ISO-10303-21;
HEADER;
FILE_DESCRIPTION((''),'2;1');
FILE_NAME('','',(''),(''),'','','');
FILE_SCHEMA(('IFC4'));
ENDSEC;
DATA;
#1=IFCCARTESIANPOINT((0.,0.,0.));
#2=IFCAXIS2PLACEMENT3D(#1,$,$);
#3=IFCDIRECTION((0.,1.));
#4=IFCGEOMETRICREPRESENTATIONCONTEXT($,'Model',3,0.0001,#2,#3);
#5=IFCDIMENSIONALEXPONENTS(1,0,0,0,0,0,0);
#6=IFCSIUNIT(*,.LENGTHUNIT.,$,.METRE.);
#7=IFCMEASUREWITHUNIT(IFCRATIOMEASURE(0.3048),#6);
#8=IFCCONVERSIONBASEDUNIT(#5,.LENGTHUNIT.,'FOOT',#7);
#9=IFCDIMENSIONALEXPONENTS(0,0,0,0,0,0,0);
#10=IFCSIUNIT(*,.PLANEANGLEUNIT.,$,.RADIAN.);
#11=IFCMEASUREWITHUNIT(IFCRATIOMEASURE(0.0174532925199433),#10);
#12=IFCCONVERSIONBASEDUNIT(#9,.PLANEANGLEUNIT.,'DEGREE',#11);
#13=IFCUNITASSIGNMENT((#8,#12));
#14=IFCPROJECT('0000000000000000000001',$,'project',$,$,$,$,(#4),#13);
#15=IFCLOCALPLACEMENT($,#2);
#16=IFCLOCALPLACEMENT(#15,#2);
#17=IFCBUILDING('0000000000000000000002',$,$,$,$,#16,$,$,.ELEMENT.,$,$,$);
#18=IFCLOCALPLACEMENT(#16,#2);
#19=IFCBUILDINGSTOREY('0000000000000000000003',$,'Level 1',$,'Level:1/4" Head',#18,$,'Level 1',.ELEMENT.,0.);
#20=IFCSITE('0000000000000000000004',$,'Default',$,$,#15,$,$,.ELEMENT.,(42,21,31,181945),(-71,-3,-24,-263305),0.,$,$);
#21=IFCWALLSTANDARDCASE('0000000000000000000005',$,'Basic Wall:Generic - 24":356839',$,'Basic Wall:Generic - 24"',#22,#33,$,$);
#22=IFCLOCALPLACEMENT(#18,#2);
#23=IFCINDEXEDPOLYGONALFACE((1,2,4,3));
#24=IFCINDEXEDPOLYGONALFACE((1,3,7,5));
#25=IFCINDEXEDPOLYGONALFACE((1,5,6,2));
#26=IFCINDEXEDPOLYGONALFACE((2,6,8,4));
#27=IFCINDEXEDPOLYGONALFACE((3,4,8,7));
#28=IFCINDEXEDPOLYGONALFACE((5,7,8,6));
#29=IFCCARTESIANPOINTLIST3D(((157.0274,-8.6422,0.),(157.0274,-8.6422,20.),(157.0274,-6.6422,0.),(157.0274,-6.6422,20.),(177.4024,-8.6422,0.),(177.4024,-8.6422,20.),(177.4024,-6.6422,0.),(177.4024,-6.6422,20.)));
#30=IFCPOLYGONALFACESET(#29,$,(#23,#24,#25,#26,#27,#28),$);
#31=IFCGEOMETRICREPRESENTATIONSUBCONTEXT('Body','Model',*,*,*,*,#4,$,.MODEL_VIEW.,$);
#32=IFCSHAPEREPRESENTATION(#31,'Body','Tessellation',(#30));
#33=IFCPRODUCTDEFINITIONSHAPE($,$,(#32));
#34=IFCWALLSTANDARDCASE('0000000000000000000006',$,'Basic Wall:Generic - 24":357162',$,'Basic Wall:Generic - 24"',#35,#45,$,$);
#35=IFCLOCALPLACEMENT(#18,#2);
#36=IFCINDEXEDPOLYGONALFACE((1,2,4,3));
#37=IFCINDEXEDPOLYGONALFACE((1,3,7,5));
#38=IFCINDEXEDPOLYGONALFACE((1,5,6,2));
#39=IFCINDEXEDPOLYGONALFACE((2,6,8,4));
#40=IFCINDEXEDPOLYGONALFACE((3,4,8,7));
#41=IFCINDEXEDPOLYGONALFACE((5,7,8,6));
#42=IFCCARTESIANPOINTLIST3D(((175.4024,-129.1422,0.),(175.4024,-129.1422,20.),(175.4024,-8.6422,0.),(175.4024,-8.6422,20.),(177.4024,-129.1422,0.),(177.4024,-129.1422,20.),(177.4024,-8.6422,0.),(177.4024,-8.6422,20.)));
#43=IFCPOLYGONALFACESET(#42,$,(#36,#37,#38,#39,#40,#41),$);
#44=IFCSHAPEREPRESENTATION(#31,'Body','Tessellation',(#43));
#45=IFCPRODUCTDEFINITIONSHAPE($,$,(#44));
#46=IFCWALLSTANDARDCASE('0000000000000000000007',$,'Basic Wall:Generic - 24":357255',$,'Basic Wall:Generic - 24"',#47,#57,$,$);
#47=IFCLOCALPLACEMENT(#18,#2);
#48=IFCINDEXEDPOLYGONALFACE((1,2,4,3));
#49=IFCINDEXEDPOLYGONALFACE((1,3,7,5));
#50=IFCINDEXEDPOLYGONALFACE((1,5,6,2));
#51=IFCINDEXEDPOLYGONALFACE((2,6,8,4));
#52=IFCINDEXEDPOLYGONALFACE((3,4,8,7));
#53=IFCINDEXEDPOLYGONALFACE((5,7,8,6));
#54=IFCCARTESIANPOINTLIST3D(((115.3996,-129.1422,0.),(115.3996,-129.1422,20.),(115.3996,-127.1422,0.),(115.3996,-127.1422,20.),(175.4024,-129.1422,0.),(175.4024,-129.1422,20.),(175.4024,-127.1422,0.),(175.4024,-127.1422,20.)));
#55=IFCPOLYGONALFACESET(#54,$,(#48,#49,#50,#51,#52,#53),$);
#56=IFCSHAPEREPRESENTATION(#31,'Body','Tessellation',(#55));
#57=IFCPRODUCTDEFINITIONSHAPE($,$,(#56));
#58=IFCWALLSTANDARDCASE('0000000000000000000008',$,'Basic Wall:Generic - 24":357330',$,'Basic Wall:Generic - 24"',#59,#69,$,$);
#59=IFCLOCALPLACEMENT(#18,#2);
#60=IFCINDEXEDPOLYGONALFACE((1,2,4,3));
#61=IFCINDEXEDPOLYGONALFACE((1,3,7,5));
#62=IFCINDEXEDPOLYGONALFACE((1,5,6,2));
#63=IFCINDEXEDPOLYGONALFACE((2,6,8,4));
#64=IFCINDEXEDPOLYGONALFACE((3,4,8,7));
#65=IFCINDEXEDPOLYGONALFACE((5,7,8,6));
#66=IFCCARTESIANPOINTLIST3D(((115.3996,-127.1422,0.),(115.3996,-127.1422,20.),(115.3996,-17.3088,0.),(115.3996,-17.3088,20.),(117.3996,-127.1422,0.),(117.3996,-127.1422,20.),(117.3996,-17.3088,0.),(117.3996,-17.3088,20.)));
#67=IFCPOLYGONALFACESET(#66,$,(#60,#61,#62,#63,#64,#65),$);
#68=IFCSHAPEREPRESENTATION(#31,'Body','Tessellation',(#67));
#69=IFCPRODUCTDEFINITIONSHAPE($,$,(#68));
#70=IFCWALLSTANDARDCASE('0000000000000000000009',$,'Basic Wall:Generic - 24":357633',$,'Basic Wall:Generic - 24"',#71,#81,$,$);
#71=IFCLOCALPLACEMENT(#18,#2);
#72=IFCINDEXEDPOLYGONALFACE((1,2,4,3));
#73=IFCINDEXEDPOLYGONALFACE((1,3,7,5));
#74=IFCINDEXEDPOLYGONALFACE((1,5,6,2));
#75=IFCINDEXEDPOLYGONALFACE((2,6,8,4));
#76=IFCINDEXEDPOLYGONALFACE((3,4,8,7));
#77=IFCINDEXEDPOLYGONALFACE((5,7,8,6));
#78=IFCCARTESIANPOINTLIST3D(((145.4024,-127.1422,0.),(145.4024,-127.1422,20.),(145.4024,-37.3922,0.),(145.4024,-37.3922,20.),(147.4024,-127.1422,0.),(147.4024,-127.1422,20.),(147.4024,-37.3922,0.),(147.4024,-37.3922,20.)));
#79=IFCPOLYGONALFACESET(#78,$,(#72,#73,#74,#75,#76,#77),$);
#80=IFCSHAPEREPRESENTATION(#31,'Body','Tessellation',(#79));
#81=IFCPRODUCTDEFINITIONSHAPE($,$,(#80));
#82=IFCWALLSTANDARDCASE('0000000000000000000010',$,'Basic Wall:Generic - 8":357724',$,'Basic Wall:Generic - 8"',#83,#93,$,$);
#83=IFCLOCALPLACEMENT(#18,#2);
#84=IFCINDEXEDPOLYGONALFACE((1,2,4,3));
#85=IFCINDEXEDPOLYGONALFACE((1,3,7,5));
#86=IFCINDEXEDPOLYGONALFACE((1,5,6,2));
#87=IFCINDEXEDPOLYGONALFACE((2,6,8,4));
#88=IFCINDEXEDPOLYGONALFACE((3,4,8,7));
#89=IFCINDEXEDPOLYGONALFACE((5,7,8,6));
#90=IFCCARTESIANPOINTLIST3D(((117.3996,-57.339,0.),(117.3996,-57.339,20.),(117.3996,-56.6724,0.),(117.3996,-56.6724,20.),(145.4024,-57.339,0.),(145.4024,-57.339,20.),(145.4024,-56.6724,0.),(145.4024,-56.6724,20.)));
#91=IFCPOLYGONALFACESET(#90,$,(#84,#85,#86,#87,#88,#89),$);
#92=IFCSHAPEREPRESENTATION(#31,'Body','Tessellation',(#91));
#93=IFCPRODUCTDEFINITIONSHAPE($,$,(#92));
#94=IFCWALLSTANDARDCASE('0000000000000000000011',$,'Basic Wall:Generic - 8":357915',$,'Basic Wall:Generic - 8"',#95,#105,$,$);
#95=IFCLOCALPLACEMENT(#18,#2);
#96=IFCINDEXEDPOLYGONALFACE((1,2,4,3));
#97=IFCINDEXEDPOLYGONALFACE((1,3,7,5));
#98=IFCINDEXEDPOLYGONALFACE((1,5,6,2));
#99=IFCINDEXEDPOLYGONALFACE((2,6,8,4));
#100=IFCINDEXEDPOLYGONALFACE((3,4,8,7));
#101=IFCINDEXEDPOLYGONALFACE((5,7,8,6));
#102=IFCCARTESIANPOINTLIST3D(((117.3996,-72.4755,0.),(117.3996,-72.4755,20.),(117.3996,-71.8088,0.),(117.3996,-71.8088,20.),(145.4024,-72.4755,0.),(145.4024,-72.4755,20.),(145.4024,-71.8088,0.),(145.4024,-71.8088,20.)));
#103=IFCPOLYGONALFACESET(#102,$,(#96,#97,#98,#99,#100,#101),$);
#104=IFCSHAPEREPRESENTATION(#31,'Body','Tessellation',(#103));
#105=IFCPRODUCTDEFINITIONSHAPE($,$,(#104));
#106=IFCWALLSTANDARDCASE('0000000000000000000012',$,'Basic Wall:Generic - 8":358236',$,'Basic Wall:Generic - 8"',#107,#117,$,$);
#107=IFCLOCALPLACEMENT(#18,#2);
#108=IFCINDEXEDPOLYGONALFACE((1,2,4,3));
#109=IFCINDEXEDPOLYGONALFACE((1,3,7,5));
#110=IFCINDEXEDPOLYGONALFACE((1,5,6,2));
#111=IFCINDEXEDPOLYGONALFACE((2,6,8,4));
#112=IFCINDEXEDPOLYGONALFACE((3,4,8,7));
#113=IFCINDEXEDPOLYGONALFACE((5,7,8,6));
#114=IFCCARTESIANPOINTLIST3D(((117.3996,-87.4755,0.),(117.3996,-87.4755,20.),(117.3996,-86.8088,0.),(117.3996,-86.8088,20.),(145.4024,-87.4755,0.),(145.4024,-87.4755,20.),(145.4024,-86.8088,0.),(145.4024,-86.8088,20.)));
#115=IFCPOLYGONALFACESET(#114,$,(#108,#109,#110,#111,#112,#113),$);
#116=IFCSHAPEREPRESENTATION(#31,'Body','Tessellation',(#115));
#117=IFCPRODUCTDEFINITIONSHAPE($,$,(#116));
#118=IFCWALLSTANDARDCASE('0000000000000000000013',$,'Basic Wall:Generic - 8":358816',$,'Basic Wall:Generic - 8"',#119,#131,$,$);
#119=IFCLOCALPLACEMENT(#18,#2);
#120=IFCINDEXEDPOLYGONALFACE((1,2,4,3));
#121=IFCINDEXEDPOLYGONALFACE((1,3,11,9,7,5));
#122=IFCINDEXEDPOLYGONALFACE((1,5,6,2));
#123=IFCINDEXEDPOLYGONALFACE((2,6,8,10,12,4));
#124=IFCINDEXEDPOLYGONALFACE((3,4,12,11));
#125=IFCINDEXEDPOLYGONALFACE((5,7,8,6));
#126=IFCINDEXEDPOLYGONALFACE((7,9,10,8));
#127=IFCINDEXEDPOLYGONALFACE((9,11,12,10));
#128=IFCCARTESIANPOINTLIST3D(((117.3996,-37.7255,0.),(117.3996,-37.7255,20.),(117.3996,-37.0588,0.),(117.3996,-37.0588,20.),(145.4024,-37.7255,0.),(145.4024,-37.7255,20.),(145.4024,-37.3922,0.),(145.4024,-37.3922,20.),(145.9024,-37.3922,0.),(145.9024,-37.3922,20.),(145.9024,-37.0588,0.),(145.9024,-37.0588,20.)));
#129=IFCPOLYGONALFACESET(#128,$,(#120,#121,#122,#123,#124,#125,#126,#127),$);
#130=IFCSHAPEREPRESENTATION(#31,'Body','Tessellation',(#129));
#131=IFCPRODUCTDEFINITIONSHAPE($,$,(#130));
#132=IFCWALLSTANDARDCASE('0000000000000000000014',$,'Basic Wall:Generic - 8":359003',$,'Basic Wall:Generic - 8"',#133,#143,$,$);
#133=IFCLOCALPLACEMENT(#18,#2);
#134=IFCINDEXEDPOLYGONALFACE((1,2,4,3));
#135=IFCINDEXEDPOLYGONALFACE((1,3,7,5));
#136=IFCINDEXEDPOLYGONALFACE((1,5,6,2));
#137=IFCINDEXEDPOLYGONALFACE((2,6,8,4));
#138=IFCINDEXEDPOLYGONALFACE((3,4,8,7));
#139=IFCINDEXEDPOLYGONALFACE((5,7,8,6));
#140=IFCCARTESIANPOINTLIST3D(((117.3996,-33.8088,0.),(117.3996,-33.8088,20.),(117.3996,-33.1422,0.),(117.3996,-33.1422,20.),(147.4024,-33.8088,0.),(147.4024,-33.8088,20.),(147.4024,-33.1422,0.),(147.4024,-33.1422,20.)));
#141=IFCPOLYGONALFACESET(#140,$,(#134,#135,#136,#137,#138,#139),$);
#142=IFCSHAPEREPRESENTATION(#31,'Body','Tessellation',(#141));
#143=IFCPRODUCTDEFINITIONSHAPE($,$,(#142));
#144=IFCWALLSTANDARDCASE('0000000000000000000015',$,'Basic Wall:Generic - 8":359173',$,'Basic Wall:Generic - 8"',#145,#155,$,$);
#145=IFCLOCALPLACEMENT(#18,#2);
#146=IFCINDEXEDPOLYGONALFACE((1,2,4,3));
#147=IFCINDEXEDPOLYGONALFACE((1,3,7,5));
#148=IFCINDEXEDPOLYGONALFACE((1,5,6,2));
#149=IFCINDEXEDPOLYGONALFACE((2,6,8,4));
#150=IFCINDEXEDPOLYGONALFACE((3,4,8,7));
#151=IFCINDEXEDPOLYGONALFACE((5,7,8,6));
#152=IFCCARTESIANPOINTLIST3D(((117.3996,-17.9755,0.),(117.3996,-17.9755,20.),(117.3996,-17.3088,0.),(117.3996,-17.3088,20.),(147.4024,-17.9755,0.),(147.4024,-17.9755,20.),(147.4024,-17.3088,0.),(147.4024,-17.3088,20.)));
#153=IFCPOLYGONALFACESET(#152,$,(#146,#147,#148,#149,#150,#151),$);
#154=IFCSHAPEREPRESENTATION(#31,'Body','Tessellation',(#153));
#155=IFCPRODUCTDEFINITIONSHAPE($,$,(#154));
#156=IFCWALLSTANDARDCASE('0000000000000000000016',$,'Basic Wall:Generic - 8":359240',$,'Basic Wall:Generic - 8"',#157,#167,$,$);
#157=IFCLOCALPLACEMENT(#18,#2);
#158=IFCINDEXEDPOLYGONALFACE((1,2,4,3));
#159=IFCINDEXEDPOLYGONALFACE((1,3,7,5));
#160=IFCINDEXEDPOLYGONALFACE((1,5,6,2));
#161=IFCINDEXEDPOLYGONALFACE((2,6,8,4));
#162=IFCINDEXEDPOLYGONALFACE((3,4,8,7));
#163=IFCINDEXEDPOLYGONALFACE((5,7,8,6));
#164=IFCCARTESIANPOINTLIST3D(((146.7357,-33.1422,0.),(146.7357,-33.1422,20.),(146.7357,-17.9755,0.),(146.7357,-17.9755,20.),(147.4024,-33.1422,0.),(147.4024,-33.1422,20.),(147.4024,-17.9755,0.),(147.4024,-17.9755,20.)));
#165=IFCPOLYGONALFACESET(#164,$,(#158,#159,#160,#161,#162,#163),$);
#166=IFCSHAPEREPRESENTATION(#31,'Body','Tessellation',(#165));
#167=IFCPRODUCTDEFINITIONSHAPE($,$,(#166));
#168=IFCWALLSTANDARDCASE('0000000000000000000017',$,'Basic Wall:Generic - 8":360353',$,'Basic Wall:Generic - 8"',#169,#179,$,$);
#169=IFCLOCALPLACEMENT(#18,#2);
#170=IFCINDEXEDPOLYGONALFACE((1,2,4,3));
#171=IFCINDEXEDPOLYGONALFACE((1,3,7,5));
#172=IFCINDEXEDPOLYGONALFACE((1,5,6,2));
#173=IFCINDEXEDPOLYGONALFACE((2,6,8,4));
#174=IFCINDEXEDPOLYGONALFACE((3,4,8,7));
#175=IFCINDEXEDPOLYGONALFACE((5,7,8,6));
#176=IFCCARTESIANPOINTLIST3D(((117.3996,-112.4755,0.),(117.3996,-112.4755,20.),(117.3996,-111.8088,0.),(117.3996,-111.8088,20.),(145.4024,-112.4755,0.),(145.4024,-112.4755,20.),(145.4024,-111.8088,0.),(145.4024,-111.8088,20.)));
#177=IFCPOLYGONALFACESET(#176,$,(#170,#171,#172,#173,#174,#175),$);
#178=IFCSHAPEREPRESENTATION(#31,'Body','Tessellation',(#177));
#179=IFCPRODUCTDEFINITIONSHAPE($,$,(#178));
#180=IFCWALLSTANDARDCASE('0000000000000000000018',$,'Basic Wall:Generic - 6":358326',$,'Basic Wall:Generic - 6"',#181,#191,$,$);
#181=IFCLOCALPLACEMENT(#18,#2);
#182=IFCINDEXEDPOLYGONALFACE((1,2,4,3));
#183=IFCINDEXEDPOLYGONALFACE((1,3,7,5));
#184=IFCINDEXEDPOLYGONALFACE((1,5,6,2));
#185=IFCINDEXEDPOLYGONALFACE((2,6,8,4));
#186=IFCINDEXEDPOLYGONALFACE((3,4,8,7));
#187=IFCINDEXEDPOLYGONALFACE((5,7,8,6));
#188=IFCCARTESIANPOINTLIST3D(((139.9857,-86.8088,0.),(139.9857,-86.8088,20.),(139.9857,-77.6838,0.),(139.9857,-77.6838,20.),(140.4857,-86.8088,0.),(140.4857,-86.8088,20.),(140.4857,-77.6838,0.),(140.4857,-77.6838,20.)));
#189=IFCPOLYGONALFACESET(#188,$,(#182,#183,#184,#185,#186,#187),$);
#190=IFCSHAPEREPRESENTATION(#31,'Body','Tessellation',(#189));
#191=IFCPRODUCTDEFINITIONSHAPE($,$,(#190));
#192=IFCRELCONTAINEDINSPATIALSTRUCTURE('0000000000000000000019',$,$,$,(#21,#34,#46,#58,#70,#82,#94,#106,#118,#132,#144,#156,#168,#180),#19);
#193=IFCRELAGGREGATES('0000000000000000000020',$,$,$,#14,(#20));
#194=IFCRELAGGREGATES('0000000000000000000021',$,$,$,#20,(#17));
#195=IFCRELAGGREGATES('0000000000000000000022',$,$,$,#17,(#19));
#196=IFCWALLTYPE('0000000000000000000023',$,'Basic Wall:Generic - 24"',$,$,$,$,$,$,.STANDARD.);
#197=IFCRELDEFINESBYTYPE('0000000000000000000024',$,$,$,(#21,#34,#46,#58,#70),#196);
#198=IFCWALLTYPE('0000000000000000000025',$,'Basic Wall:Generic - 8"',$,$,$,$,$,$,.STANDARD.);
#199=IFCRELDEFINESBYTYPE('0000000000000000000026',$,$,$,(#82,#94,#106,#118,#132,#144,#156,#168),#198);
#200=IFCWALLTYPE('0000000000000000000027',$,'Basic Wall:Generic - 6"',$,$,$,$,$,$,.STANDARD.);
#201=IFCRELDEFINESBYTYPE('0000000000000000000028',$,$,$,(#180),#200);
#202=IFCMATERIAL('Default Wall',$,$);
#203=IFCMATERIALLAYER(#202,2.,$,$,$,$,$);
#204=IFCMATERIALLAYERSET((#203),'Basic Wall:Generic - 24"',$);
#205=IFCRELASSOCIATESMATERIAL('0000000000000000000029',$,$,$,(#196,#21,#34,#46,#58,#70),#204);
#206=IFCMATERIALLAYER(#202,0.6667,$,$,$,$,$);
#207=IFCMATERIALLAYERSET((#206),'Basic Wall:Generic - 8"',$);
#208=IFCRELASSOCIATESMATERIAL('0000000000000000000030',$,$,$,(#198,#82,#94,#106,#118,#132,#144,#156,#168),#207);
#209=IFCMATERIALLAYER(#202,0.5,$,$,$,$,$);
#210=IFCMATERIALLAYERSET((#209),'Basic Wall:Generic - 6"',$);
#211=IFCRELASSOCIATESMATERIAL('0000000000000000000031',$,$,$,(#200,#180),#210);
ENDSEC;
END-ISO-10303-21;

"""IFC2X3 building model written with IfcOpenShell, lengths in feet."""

from ifc_helpers import new_model, entity, si_unit, converted_unit, direction, frame, frame_2d, origin, place, context, subcontext, project, spatial, polyline, rectangle, outline, extrude, material, layer, layer_set, layer_usage, type_object, element, save


model = new_model("IFC2X3")

# Units and contexts
model_context = context("Model", 3, precision=0.0001, world=origin(), true_north=direction((0.0, 1.0)))
body_context = subcontext(model_context, "Body", "Model", "MODEL_VIEW")
ifc_project = project(units=[converted_unit("LENGTHUNIT", "FOOT", entity("IfcRatioMeasure", 0.3048), si_unit("LENGTHUNIT", "METRE"), dimensions=[1, 0, 0, 0, 0, 0, 0]), converted_unit("PLANEANGLEUNIT", "DEGREE", entity("IfcRatioMeasure", 0.0174532925199433), si_unit("PLANEANGLEUNIT", "RADIAN"), dimensions=[0, 0, 0, 0, 0, 0, 0])], contexts=[model_context])

# Site, building, storey
site_placement = place(None, origin())
site = spatial("IfcSite", under=ifc_project, at=site_placement, Name="Default", CompositionType="ELEMENT", RefLatitude=(42, 21, 31, 181945), RefLongitude=(-71, -3, -24, -263305), RefElevation=0.0)
building_placement = place(site_placement, origin())
building = spatial("IfcBuilding", under=site, at=building_placement, CompositionType="ELEMENT")
storey_placement = place(building_placement, origin())
storey = spatial("IfcBuildingStorey", under=building, at=storey_placement, Name="Level 1", ObjectType="Level:1/4\" Head", LongName="Level 1", CompositionType="ELEMENT", Elevation=0.0)

# Walls
ifc_material = material(Name="Default Wall")
ifc_layer_1 = layer(ifc_material, 2.0)
ifc_layer_set_1 = layer_set([ifc_layer_1], Name="Basic Wall:Generic - 24\"")
ifc_layer_usage_1 = layer_usage(ifc_layer_set_1, "AXIS2", "NEGATIVE", 1.0)
wall_type_1 = type_object("IfcWallType", Name="Basic Wall:Generic - 24\"", PredefinedType="STANDARD", material=ifc_layer_set_1)
wall_1_placement = place(storey_placement, frame((157.0274, -7.6422, 0.0)))
element("IfcWallStandardCase", 1, at=wall_1_placement, inside=storey, type_object=wall_type_1, material=ifc_layer_usage_1, Name="Basic Wall:Generic - 24\":356839", ObjectType="Basic Wall:Generic - 24\"", context=body_context, shape_type="SweptSolid", body=[
    extrude(rectangle(XDim=20.375, YDim=2.0, at=frame_2d((10.1875, 0.0), x_axis=(-1.0, 0.0))), origin(), (0.0, 0.0, 1.0), 20.0),
])
ifc_layer_usage_2 = layer_usage(ifc_layer_set_1, "AXIS2", "NEGATIVE", 1.0)
wall_2_placement = place(storey_placement, frame((176.4024, -8.6422, 0.0), z_axis=(0.0, 0.0, 1.0), x_axis=(0.0, -1.0, 0.0)))
element("IfcWallStandardCase", 2, at=wall_2_placement, inside=storey, type_object=wall_type_1, material=ifc_layer_usage_2, Name="Basic Wall:Generic - 24\":357162", ObjectType="Basic Wall:Generic - 24\"", context=body_context, shape_type="SweptSolid", body=[
    extrude(rectangle(XDim=120.5, YDim=2.0, at=frame_2d((60.25, 0.0), x_axis=(-1.0, 0.0))), origin(), (0.0, 0.0, 1.0), 20.0),
])
ifc_layer_usage_3 = layer_usage(ifc_layer_set_1, "AXIS2", "NEGATIVE", 1.0)
wall_3_placement = place(storey_placement, frame((175.4024, -128.1422, 0.0), z_axis=(0.0, 0.0, 1.0), x_axis=(-1.0, 0.0, 0.0)))
element("IfcWallStandardCase", 3, at=wall_3_placement, inside=storey, type_object=wall_type_1, material=ifc_layer_usage_3, Name="Basic Wall:Generic - 24\":357255", ObjectType="Basic Wall:Generic - 24\"", context=body_context, shape_type="SweptSolid", body=[
    extrude(rectangle(XDim=60.0028, YDim=2.0, at=frame_2d((30.0014, 0.0), x_axis=(-1.0, 0.0))), origin(), (0.0, 0.0, 1.0), 20.0),
])
ifc_layer_usage_4 = layer_usage(ifc_layer_set_1, "AXIS2", "NEGATIVE", 1.0)
wall_4_placement = place(storey_placement, frame((116.3996, -127.1422, 0.0), z_axis=(0.0, 0.0, 1.0), x_axis=(0.0, 1.0, 0.0)))
element("IfcWallStandardCase", 4, at=wall_4_placement, inside=storey, type_object=wall_type_1, material=ifc_layer_usage_4, Name="Basic Wall:Generic - 24\":357330", ObjectType="Basic Wall:Generic - 24\"", context=body_context, shape_type="SweptSolid", body=[
    extrude(rectangle(XDim=109.8333, YDim=2.0, at=frame_2d((54.9167, 0.0), x_axis=(-1.0, 0.0))), origin(), (0.0, 0.0, 1.0), 20.0),
])
ifc_layer_usage_5 = layer_usage(ifc_layer_set_1, "AXIS2", "NEGATIVE", 1.0)
wall_5_placement = place(storey_placement, frame((146.4024, -37.3922, 0.0), z_axis=(0.0, 0.0, 1.0), x_axis=(0.0, -1.0, 0.0)))
element("IfcWallStandardCase", 5, at=wall_5_placement, inside=storey, type_object=wall_type_1, material=ifc_layer_usage_5, Name="Basic Wall:Generic - 24\":357633", ObjectType="Basic Wall:Generic - 24\"", context=body_context, shape_type="SweptSolid", body=[
    extrude(rectangle(XDim=89.75, YDim=2.0, at=frame_2d((44.875, 0.0), x_axis=(-1.0, 0.0))), origin(), (0.0, 0.0, 1.0), 20.0),
])
ifc_layer_2 = layer(ifc_material, 0.6667)
ifc_layer_set_2 = layer_set([ifc_layer_2], Name="Basic Wall:Generic - 8\"")
ifc_layer_usage_6 = layer_usage(ifc_layer_set_2, "AXIS2", "NEGATIVE", 0.3333)
wall_type_2 = type_object("IfcWallType", Name="Basic Wall:Generic - 8\"", PredefinedType="STANDARD", material=ifc_layer_set_2)
wall_6_placement = place(storey_placement, frame((117.3996, -57.0057, 0.0)))
element("IfcWallStandardCase", 6, at=wall_6_placement, inside=storey, type_object=wall_type_2, material=ifc_layer_usage_6, Name="Basic Wall:Generic - 8\":357724", ObjectType="Basic Wall:Generic - 8\"", context=body_context, shape_type="SweptSolid", body=[
    extrude(rectangle(XDim=28.0028, YDim=0.6667, at=frame_2d((14.0014, 0.0), x_axis=(-1.0, 0.0))), origin(), (0.0, 0.0, 1.0), 20.0),
])
ifc_layer_usage_7 = layer_usage(ifc_layer_set_2, "AXIS2", "NEGATIVE", 0.3333)
wall_7_placement = place(storey_placement, frame((117.3996, -72.1422, 0.0)))
element("IfcWallStandardCase", 7, at=wall_7_placement, inside=storey, type_object=wall_type_2, material=ifc_layer_usage_7, Name="Basic Wall:Generic - 8\":357915", ObjectType="Basic Wall:Generic - 8\"", context=body_context, shape_type="SweptSolid", body=[
    extrude(rectangle(XDim=28.0028, YDim=0.6667, at=frame_2d((14.0014, 0.0), x_axis=(-1.0, 0.0))), origin(), (0.0, 0.0, 1.0), 20.0),
])
ifc_layer_usage_8 = layer_usage(ifc_layer_set_2, "AXIS2", "NEGATIVE", 0.3333)
wall_8_placement = place(storey_placement, frame((117.3996, -87.1422, 0.0)))
element("IfcWallStandardCase", 8, at=wall_8_placement, inside=storey, type_object=wall_type_2, material=ifc_layer_usage_8, Name="Basic Wall:Generic - 8\":358236", ObjectType="Basic Wall:Generic - 8\"", context=body_context, shape_type="SweptSolid", body=[
    extrude(rectangle(XDim=28.0028, YDim=0.6667, at=frame_2d((14.0014, 0.0), x_axis=(-1.0, 0.0))), origin(), (0.0, 0.0, 1.0), 20.0),
])
ifc_layer_usage_9 = layer_usage(ifc_layer_set_2, "AXIS2", "NEGATIVE", 0.3333)
wall_9_placement = place(storey_placement, frame((117.3996, -37.3922, 0.0)))
element("IfcWallStandardCase", 9, at=wall_9_placement, inside=storey, type_object=wall_type_2, material=ifc_layer_usage_9, Name="Basic Wall:Generic - 8\":358816", ObjectType="Basic Wall:Generic - 8\"", context=body_context, shape_type="SweptSolid", body=[
    extrude(outline(polyline([(28.0028, -0.3333), (28.0028, 0.0), (28.5028, 0.0), (28.5028, 0.3333), (0.0, 0.3333), (0.0, -0.3333), (28.0028, -0.3333)])), origin(), (0.0, 0.0, 1.0), 20.0),
])
ifc_layer_usage_10 = layer_usage(ifc_layer_set_2, "AXIS2", "NEGATIVE", 0.3333)
wall_10_placement = place(storey_placement, frame((117.3996, -33.4755, 0.0)))
element("IfcWallStandardCase", 10, at=wall_10_placement, inside=storey, type_object=wall_type_2, material=ifc_layer_usage_10, Name="Basic Wall:Generic - 8\":359003", ObjectType="Basic Wall:Generic - 8\"", context=body_context, shape_type="SweptSolid", body=[
    extrude(rectangle(XDim=30.0028, YDim=0.6667, at=frame_2d((15.0014, 0.0), x_axis=(-1.0, 0.0))), origin(), (0.0, 0.0, 1.0), 20.0),
])
ifc_layer_usage_11 = layer_usage(ifc_layer_set_2, "AXIS2", "NEGATIVE", 0.3333)
wall_11_placement = place(storey_placement, frame((117.3996, -17.6422, 0.0)))
element("IfcWallStandardCase", 11, at=wall_11_placement, inside=storey, type_object=wall_type_2, material=ifc_layer_usage_11, Name="Basic Wall:Generic - 8\":359173", ObjectType="Basic Wall:Generic - 8\"", context=body_context, shape_type="SweptSolid", body=[
    extrude(rectangle(XDim=30.0028, YDim=0.6667, at=frame_2d((15.0014, 0.0), x_axis=(-1.0, 0.0))), origin(), (0.0, 0.0, 1.0), 20.0),
])
ifc_layer_usage_12 = layer_usage(ifc_layer_set_2, "AXIS2", "NEGATIVE", 0.3333)
wall_12_placement = place(storey_placement, frame((147.069, -17.9755, 0.0), z_axis=(0.0, 0.0, 1.0), x_axis=(0.0, -1.0, 0.0)))
element("IfcWallStandardCase", 12, at=wall_12_placement, inside=storey, type_object=wall_type_2, material=ifc_layer_usage_12, Name="Basic Wall:Generic - 8\":359240", ObjectType="Basic Wall:Generic - 8\"", context=body_context, shape_type="SweptSolid", body=[
    extrude(rectangle(XDim=15.1667, YDim=0.6667, at=frame_2d((7.5833, 0.0), x_axis=(-1.0, 0.0))), origin(), (0.0, 0.0, 1.0), 20.0),
])
ifc_layer_usage_13 = layer_usage(ifc_layer_set_2, "AXIS2", "NEGATIVE", 0.3333)
wall_13_placement = place(storey_placement, frame((117.3996, -112.1422, 0.0)))
element("IfcWallStandardCase", 13, at=wall_13_placement, inside=storey, type_object=wall_type_2, material=ifc_layer_usage_13, Name="Basic Wall:Generic - 8\":360353", ObjectType="Basic Wall:Generic - 8\"", context=body_context, shape_type="SweptSolid", body=[
    extrude(rectangle(XDim=28.0028, YDim=0.6667, at=frame_2d((14.0014, 0.0), x_axis=(-1.0, 0.0))), origin(), (0.0, 0.0, 1.0), 20.0),
])
ifc_layer_3 = layer(ifc_material, 0.5)
ifc_layer_set_3 = layer_set([ifc_layer_3], Name="Basic Wall:Generic - 6\"")
ifc_layer_usage_14 = layer_usage(ifc_layer_set_3, "AXIS2", "NEGATIVE", 0.25)
wall_type_3 = type_object("IfcWallType", Name="Basic Wall:Generic - 6\"", PredefinedType="STANDARD", material=ifc_layer_set_3)
wall_14_placement = place(storey_placement, frame((140.2357, -86.8088, 0.0), z_axis=(0.0, 0.0, 1.0), x_axis=(0.0, 1.0, 0.0)))
element("IfcWallStandardCase", 14, at=wall_14_placement, inside=storey, type_object=wall_type_3, material=ifc_layer_usage_14, Name="Basic Wall:Generic - 6\":358326", ObjectType="Basic Wall:Generic - 6\"", context=body_context, shape_type="SweptSolid", body=[
    extrude(rectangle(XDim=9.125, YDim=0.5, at=frame_2d((4.5625, 0.0), x_axis=(-1.0, 0.0))), origin(), (0.0, 0.0, 1.0), 20.0),
])

save(model, "model.ifc")
